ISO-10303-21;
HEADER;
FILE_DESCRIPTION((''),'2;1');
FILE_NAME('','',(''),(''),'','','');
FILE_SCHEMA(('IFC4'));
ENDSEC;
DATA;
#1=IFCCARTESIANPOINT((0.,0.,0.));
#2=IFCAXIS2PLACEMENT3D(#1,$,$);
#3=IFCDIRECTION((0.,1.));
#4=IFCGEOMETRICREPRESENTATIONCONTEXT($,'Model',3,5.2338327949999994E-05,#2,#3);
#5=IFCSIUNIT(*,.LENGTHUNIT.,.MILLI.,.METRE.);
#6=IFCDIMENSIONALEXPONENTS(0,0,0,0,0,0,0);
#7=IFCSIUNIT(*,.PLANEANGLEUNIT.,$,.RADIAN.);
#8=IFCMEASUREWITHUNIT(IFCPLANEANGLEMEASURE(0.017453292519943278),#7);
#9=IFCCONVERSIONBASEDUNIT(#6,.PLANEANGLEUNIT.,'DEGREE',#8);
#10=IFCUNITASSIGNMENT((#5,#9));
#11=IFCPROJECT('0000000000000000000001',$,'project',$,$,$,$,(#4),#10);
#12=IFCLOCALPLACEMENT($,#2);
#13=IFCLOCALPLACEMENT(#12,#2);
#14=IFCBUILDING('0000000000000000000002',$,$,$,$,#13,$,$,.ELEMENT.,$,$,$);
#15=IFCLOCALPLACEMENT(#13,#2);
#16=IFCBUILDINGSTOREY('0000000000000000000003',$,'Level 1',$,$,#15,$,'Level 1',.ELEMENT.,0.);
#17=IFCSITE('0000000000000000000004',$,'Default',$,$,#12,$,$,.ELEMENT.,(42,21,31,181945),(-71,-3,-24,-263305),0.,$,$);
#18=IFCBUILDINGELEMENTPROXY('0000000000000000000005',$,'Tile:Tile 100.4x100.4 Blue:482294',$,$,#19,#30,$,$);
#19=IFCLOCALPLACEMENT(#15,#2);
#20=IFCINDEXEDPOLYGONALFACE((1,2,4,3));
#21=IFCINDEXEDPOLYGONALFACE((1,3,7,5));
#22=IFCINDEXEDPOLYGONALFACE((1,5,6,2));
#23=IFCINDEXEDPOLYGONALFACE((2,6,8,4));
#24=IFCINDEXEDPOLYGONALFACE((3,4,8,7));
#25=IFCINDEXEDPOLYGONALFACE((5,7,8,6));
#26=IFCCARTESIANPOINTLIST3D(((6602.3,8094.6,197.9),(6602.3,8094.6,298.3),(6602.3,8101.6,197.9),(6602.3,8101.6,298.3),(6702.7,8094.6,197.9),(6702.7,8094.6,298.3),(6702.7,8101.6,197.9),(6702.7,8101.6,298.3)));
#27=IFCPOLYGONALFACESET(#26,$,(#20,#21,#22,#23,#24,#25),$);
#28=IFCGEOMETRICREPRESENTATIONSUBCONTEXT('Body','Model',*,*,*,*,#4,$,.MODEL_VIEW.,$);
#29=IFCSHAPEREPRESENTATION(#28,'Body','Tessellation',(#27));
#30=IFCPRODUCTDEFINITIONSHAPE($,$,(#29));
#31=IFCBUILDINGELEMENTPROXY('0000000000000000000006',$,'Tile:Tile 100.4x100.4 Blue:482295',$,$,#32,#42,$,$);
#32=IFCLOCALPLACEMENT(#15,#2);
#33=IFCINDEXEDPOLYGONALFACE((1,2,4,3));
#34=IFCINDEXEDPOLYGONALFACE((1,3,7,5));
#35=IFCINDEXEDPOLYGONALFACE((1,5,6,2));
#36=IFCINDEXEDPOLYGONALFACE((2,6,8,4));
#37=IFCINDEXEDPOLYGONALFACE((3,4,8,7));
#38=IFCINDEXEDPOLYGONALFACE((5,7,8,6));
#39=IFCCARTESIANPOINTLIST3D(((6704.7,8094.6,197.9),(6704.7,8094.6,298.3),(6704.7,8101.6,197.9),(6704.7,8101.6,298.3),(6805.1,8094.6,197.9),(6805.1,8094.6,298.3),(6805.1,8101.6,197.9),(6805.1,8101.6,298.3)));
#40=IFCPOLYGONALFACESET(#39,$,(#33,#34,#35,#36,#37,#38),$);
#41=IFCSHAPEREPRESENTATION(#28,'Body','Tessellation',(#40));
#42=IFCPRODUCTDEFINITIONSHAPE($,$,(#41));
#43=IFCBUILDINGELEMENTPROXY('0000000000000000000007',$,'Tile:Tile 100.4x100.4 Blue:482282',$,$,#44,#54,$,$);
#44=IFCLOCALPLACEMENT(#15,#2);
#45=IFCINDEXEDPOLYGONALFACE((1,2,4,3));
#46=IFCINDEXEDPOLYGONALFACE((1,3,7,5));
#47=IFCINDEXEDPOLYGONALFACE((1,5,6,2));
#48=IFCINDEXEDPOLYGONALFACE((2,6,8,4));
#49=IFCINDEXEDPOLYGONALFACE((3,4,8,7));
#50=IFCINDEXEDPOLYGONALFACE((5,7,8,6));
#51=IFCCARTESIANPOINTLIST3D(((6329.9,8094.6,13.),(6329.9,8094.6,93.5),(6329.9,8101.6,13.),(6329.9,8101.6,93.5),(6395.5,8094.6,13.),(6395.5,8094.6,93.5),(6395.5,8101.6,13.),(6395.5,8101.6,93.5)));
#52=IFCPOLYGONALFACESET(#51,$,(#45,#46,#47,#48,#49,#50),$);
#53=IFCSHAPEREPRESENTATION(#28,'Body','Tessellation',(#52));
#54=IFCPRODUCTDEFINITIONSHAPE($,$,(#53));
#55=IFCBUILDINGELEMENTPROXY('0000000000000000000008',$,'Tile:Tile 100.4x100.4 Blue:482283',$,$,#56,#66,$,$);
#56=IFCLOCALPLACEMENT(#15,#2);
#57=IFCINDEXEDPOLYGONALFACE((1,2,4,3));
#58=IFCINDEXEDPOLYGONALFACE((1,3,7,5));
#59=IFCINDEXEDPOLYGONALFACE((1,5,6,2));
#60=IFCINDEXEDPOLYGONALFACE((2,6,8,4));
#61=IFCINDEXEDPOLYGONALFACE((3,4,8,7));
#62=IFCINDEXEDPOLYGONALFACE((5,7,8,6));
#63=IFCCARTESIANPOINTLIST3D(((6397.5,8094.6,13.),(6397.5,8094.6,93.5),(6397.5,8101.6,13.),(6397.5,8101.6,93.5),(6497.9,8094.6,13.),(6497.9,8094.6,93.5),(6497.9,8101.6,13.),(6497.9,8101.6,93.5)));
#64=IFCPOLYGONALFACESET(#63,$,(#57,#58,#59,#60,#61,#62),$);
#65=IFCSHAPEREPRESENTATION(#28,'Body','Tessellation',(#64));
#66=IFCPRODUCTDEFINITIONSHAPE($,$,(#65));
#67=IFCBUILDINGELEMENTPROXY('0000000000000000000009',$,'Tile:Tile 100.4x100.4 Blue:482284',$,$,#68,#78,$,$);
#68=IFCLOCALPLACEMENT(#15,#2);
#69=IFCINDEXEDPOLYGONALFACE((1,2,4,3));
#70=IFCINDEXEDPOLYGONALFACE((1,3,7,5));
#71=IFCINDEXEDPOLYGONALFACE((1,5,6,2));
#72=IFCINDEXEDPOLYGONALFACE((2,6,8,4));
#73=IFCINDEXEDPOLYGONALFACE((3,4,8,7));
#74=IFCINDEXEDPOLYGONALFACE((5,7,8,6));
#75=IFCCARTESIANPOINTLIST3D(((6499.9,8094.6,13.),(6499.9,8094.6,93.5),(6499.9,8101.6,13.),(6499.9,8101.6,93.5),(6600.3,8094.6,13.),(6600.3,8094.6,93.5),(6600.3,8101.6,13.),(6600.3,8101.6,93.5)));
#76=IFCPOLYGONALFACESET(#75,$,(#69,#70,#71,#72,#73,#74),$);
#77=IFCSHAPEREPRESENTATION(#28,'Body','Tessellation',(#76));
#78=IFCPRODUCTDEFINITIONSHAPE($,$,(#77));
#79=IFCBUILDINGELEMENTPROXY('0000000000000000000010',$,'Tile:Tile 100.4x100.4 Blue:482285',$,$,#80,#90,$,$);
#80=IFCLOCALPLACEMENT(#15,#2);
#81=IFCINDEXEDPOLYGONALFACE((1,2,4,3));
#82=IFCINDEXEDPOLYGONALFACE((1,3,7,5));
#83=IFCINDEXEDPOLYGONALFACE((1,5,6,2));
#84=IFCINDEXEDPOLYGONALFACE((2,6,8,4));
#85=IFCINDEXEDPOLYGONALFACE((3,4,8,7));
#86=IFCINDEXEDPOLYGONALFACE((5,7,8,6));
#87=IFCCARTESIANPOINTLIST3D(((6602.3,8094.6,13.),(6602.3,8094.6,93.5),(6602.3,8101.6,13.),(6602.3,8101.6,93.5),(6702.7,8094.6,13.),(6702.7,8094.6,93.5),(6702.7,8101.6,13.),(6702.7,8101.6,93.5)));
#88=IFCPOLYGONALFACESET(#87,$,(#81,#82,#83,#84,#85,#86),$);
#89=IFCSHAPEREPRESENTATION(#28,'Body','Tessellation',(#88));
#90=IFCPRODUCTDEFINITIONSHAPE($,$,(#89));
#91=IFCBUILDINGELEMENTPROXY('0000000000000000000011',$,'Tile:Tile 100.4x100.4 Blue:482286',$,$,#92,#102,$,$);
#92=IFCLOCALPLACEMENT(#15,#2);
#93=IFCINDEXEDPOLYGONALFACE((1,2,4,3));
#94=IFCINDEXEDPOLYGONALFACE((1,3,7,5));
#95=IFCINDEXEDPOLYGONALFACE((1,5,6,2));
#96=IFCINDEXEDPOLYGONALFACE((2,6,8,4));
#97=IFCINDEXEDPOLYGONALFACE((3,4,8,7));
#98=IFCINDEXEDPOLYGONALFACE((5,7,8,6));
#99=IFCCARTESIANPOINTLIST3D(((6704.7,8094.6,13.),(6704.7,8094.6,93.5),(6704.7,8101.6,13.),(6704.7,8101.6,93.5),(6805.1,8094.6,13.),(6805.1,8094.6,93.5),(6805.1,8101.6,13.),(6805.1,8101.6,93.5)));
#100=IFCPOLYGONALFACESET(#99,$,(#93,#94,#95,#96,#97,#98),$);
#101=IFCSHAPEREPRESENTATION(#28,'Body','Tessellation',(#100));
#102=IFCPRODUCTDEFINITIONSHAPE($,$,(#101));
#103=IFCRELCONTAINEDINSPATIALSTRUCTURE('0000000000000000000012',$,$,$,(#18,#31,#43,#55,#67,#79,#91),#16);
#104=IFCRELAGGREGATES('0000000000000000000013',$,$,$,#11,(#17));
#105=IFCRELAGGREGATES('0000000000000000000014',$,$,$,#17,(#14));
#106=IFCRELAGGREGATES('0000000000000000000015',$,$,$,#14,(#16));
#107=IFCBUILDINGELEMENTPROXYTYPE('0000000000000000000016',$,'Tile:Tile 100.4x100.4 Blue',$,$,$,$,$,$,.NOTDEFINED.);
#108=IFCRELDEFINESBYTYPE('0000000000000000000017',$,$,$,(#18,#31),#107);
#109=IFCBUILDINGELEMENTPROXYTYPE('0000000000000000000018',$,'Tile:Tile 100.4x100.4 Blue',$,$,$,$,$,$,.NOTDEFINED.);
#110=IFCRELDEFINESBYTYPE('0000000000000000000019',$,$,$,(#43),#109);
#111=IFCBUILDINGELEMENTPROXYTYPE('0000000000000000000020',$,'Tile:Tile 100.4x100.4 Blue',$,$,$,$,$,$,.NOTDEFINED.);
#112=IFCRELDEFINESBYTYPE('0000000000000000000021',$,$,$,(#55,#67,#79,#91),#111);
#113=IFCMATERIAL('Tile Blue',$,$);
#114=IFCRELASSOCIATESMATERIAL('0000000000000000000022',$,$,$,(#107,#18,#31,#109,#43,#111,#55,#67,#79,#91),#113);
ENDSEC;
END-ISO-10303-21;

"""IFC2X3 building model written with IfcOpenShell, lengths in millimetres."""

from ifc_helpers import new_model, entity, si_unit, converted_unit, direction, frame, frame_2d, origin, origin_2d_with_axis, place, context, subcontext, project, spatial, rectangle, extrude, source, transform, mapped, material, type_object, type_shapes, element, save


model = new_model("IFC2X3")

# Units and contexts
model_context = context("Model", 3, precision=5.2338327949999994e-05, world=origin(), true_north=direction((0.0, 1.0)))
body_context = subcontext(model_context, "Body", "Model", "MODEL_VIEW")
ifc_project = project(units=[si_unit("LENGTHUNIT", "METRE", prefix="MILLI"), converted_unit("PLANEANGLEUNIT", "DEGREE", entity("IfcPlaneAngleMeasure", 0.017453292519943278), si_unit("PLANEANGLEUNIT", "RADIAN"), dimensions=[0, 0, 0, 0, 0, 0, 0])], contexts=[model_context])

# Site, building, storey
site_placement = place(None, origin())
site = spatial("IfcSite", under=ifc_project, at=site_placement, Name="Default", CompositionType="ELEMENT", RefLatitude=(42, 21, 31, 181945), RefLongitude=(-71, -3, -24, -263305), RefElevation=0.0)
building_placement = place(site_placement, origin())
building = spatial("IfcBuilding", under=site, at=building_placement, CompositionType="ELEMENT")
storey_placement = place(building_placement, origin())
storey = spatial("IfcBuildingStorey", under=building, at=storey_placement, Name="Level 1", LongName="Level 1", CompositionType="ELEMENT", Elevation=0.0)

# Building element proxies
ifc_material_1 = material(Name="Tile Blue")
building_element_proxy_type_1 = type_object("IfcBuildingElementProxyType", Name="Tile:Tile 100.4x100.4 Blue", PredefinedType="NOTDEFINED", material=ifc_material_1)
shared_shape_1 = source(origin(), body_context, "Body", "SweptSolid", [
    extrude(rectangle(XDim=100.4, YDim=100.4, at=origin_2d_with_axis()), frame((-50.2, -50.2, 0.0), z_axis=(0.0, 0.0, 1.0), x_axis=(0.0, -1.0, 0.0)), (0.0, 0.0, 1.0), 7.0),
])
type_shapes(building_element_proxy_type_1, [shared_shape_1])
for number, where, z_axis, x_axis, name in (
    (1, (6602.3, 8101.6, 197.9), (0.0, -1.0, 0.0), (-1.0, 0.0, 0.0), "Tile:Tile 100.4x100.4 Blue:482294"),
    (2, (6704.7, 8101.6, 197.9), (0.0, -1.0, 0.0), (-1.0, 0.0, 0.0), "Tile:Tile 100.4x100.4 Blue:482295"),
):
    element("IfcBuildingElementProxy", number, at=place(storey_placement, frame(where, z_axis=z_axis, x_axis=x_axis)), inside=storey, type_object=building_element_proxy_type_1, material=ifc_material_1, Name=name, context=body_context, shape_type="MappedRepresentation", body=[
        mapped(shared_shape_1, transform((0.0, 0.0, 0.0), scale=1.0)),
    ])
building_element_proxy_type_2 = type_object("IfcBuildingElementProxyType", Name="Tile:Tile 100.4x100.4 Blue", PredefinedType="NOTDEFINED", material=ifc_material_1)
shared_shape_2 = source(origin(), body_context, "Body", "SweptSolid", [
    extrude(rectangle(XDim=65.6, YDim=80.5, at=frame_2d((0.0, 0.0), x_axis=(1.0, 0.0))), frame((-32.8, -40.3, 0.0), z_axis=(0.0, 0.0, 1.0), x_axis=(-1.0, 0.0, 0.0)), (0.0, 0.0, 1.0), 7.0),
])
type_shapes(building_element_proxy_type_2, [shared_shape_2])
proxy_placement = place(storey_placement, frame((6329.9, 8101.6, 13.0), z_axis=(0.0, -1.0, 0.0), x_axis=(-1.0, 0.0, 0.0)))
element("IfcBuildingElementProxy", 3, at=proxy_placement, inside=storey, type_object=building_element_proxy_type_2, material=ifc_material_1, Name="Tile:Tile 100.4x100.4 Blue:482282", context=body_context, shape_type="MappedRepresentation", body=[
    mapped(shared_shape_2, transform((0.0, 0.0, 0.0), scale=1.0)),
])
building_element_proxy_type_3 = type_object("IfcBuildingElementProxyType", Name="Tile:Tile 100.4x100.4 Blue", PredefinedType="NOTDEFINED", material=ifc_material_1)
shared_shape_3 = source(origin(), body_context, "Body", "SweptSolid", [
    extrude(rectangle(XDim=80.5, YDim=100.4, at=origin_2d_with_axis()), frame((-50.2, -40.3, 0.0), z_axis=(0.0, 0.0, 1.0), x_axis=(0.0, -1.0, 0.0)), (0.0, 0.0, 1.0), 7.0),
])
type_shapes(building_element_proxy_type_3, [shared_shape_3])
for number, where, z_axis, x_axis, name in (
    (4, (6397.5, 8101.6, 13.0), (0.0, -1.0, 0.0), (-1.0, 0.0, 0.0), "Tile:Tile 100.4x100.4 Blue:482283"),
    (5, (6499.9, 8101.6, 13.0), (0.0, -1.0, 0.0), (-1.0, 0.0, 0.0), "Tile:Tile 100.4x100.4 Blue:482284"),
    (6, (6602.3, 8101.6, 13.0), (0.0, -1.0, 0.0), (-1.0, 0.0, 0.0), "Tile:Tile 100.4x100.4 Blue:482285"),
    (7, (6704.7, 8101.6, 13.0), (0.0, -1.0, 0.0), (-1.0, 0.0, 0.0), "Tile:Tile 100.4x100.4 Blue:482286"),
):
    element("IfcBuildingElementProxy", number, at=place(storey_placement, frame(where, z_axis=z_axis, x_axis=x_axis)), inside=storey, type_object=building_element_proxy_type_3, material=ifc_material_1, Name=name, context=body_context, shape_type="MappedRepresentation", body=[
        mapped(shared_shape_3, transform((0.0, 0.0, 0.0), scale=1.0)),
    ])

save(model, "model.ifc")
